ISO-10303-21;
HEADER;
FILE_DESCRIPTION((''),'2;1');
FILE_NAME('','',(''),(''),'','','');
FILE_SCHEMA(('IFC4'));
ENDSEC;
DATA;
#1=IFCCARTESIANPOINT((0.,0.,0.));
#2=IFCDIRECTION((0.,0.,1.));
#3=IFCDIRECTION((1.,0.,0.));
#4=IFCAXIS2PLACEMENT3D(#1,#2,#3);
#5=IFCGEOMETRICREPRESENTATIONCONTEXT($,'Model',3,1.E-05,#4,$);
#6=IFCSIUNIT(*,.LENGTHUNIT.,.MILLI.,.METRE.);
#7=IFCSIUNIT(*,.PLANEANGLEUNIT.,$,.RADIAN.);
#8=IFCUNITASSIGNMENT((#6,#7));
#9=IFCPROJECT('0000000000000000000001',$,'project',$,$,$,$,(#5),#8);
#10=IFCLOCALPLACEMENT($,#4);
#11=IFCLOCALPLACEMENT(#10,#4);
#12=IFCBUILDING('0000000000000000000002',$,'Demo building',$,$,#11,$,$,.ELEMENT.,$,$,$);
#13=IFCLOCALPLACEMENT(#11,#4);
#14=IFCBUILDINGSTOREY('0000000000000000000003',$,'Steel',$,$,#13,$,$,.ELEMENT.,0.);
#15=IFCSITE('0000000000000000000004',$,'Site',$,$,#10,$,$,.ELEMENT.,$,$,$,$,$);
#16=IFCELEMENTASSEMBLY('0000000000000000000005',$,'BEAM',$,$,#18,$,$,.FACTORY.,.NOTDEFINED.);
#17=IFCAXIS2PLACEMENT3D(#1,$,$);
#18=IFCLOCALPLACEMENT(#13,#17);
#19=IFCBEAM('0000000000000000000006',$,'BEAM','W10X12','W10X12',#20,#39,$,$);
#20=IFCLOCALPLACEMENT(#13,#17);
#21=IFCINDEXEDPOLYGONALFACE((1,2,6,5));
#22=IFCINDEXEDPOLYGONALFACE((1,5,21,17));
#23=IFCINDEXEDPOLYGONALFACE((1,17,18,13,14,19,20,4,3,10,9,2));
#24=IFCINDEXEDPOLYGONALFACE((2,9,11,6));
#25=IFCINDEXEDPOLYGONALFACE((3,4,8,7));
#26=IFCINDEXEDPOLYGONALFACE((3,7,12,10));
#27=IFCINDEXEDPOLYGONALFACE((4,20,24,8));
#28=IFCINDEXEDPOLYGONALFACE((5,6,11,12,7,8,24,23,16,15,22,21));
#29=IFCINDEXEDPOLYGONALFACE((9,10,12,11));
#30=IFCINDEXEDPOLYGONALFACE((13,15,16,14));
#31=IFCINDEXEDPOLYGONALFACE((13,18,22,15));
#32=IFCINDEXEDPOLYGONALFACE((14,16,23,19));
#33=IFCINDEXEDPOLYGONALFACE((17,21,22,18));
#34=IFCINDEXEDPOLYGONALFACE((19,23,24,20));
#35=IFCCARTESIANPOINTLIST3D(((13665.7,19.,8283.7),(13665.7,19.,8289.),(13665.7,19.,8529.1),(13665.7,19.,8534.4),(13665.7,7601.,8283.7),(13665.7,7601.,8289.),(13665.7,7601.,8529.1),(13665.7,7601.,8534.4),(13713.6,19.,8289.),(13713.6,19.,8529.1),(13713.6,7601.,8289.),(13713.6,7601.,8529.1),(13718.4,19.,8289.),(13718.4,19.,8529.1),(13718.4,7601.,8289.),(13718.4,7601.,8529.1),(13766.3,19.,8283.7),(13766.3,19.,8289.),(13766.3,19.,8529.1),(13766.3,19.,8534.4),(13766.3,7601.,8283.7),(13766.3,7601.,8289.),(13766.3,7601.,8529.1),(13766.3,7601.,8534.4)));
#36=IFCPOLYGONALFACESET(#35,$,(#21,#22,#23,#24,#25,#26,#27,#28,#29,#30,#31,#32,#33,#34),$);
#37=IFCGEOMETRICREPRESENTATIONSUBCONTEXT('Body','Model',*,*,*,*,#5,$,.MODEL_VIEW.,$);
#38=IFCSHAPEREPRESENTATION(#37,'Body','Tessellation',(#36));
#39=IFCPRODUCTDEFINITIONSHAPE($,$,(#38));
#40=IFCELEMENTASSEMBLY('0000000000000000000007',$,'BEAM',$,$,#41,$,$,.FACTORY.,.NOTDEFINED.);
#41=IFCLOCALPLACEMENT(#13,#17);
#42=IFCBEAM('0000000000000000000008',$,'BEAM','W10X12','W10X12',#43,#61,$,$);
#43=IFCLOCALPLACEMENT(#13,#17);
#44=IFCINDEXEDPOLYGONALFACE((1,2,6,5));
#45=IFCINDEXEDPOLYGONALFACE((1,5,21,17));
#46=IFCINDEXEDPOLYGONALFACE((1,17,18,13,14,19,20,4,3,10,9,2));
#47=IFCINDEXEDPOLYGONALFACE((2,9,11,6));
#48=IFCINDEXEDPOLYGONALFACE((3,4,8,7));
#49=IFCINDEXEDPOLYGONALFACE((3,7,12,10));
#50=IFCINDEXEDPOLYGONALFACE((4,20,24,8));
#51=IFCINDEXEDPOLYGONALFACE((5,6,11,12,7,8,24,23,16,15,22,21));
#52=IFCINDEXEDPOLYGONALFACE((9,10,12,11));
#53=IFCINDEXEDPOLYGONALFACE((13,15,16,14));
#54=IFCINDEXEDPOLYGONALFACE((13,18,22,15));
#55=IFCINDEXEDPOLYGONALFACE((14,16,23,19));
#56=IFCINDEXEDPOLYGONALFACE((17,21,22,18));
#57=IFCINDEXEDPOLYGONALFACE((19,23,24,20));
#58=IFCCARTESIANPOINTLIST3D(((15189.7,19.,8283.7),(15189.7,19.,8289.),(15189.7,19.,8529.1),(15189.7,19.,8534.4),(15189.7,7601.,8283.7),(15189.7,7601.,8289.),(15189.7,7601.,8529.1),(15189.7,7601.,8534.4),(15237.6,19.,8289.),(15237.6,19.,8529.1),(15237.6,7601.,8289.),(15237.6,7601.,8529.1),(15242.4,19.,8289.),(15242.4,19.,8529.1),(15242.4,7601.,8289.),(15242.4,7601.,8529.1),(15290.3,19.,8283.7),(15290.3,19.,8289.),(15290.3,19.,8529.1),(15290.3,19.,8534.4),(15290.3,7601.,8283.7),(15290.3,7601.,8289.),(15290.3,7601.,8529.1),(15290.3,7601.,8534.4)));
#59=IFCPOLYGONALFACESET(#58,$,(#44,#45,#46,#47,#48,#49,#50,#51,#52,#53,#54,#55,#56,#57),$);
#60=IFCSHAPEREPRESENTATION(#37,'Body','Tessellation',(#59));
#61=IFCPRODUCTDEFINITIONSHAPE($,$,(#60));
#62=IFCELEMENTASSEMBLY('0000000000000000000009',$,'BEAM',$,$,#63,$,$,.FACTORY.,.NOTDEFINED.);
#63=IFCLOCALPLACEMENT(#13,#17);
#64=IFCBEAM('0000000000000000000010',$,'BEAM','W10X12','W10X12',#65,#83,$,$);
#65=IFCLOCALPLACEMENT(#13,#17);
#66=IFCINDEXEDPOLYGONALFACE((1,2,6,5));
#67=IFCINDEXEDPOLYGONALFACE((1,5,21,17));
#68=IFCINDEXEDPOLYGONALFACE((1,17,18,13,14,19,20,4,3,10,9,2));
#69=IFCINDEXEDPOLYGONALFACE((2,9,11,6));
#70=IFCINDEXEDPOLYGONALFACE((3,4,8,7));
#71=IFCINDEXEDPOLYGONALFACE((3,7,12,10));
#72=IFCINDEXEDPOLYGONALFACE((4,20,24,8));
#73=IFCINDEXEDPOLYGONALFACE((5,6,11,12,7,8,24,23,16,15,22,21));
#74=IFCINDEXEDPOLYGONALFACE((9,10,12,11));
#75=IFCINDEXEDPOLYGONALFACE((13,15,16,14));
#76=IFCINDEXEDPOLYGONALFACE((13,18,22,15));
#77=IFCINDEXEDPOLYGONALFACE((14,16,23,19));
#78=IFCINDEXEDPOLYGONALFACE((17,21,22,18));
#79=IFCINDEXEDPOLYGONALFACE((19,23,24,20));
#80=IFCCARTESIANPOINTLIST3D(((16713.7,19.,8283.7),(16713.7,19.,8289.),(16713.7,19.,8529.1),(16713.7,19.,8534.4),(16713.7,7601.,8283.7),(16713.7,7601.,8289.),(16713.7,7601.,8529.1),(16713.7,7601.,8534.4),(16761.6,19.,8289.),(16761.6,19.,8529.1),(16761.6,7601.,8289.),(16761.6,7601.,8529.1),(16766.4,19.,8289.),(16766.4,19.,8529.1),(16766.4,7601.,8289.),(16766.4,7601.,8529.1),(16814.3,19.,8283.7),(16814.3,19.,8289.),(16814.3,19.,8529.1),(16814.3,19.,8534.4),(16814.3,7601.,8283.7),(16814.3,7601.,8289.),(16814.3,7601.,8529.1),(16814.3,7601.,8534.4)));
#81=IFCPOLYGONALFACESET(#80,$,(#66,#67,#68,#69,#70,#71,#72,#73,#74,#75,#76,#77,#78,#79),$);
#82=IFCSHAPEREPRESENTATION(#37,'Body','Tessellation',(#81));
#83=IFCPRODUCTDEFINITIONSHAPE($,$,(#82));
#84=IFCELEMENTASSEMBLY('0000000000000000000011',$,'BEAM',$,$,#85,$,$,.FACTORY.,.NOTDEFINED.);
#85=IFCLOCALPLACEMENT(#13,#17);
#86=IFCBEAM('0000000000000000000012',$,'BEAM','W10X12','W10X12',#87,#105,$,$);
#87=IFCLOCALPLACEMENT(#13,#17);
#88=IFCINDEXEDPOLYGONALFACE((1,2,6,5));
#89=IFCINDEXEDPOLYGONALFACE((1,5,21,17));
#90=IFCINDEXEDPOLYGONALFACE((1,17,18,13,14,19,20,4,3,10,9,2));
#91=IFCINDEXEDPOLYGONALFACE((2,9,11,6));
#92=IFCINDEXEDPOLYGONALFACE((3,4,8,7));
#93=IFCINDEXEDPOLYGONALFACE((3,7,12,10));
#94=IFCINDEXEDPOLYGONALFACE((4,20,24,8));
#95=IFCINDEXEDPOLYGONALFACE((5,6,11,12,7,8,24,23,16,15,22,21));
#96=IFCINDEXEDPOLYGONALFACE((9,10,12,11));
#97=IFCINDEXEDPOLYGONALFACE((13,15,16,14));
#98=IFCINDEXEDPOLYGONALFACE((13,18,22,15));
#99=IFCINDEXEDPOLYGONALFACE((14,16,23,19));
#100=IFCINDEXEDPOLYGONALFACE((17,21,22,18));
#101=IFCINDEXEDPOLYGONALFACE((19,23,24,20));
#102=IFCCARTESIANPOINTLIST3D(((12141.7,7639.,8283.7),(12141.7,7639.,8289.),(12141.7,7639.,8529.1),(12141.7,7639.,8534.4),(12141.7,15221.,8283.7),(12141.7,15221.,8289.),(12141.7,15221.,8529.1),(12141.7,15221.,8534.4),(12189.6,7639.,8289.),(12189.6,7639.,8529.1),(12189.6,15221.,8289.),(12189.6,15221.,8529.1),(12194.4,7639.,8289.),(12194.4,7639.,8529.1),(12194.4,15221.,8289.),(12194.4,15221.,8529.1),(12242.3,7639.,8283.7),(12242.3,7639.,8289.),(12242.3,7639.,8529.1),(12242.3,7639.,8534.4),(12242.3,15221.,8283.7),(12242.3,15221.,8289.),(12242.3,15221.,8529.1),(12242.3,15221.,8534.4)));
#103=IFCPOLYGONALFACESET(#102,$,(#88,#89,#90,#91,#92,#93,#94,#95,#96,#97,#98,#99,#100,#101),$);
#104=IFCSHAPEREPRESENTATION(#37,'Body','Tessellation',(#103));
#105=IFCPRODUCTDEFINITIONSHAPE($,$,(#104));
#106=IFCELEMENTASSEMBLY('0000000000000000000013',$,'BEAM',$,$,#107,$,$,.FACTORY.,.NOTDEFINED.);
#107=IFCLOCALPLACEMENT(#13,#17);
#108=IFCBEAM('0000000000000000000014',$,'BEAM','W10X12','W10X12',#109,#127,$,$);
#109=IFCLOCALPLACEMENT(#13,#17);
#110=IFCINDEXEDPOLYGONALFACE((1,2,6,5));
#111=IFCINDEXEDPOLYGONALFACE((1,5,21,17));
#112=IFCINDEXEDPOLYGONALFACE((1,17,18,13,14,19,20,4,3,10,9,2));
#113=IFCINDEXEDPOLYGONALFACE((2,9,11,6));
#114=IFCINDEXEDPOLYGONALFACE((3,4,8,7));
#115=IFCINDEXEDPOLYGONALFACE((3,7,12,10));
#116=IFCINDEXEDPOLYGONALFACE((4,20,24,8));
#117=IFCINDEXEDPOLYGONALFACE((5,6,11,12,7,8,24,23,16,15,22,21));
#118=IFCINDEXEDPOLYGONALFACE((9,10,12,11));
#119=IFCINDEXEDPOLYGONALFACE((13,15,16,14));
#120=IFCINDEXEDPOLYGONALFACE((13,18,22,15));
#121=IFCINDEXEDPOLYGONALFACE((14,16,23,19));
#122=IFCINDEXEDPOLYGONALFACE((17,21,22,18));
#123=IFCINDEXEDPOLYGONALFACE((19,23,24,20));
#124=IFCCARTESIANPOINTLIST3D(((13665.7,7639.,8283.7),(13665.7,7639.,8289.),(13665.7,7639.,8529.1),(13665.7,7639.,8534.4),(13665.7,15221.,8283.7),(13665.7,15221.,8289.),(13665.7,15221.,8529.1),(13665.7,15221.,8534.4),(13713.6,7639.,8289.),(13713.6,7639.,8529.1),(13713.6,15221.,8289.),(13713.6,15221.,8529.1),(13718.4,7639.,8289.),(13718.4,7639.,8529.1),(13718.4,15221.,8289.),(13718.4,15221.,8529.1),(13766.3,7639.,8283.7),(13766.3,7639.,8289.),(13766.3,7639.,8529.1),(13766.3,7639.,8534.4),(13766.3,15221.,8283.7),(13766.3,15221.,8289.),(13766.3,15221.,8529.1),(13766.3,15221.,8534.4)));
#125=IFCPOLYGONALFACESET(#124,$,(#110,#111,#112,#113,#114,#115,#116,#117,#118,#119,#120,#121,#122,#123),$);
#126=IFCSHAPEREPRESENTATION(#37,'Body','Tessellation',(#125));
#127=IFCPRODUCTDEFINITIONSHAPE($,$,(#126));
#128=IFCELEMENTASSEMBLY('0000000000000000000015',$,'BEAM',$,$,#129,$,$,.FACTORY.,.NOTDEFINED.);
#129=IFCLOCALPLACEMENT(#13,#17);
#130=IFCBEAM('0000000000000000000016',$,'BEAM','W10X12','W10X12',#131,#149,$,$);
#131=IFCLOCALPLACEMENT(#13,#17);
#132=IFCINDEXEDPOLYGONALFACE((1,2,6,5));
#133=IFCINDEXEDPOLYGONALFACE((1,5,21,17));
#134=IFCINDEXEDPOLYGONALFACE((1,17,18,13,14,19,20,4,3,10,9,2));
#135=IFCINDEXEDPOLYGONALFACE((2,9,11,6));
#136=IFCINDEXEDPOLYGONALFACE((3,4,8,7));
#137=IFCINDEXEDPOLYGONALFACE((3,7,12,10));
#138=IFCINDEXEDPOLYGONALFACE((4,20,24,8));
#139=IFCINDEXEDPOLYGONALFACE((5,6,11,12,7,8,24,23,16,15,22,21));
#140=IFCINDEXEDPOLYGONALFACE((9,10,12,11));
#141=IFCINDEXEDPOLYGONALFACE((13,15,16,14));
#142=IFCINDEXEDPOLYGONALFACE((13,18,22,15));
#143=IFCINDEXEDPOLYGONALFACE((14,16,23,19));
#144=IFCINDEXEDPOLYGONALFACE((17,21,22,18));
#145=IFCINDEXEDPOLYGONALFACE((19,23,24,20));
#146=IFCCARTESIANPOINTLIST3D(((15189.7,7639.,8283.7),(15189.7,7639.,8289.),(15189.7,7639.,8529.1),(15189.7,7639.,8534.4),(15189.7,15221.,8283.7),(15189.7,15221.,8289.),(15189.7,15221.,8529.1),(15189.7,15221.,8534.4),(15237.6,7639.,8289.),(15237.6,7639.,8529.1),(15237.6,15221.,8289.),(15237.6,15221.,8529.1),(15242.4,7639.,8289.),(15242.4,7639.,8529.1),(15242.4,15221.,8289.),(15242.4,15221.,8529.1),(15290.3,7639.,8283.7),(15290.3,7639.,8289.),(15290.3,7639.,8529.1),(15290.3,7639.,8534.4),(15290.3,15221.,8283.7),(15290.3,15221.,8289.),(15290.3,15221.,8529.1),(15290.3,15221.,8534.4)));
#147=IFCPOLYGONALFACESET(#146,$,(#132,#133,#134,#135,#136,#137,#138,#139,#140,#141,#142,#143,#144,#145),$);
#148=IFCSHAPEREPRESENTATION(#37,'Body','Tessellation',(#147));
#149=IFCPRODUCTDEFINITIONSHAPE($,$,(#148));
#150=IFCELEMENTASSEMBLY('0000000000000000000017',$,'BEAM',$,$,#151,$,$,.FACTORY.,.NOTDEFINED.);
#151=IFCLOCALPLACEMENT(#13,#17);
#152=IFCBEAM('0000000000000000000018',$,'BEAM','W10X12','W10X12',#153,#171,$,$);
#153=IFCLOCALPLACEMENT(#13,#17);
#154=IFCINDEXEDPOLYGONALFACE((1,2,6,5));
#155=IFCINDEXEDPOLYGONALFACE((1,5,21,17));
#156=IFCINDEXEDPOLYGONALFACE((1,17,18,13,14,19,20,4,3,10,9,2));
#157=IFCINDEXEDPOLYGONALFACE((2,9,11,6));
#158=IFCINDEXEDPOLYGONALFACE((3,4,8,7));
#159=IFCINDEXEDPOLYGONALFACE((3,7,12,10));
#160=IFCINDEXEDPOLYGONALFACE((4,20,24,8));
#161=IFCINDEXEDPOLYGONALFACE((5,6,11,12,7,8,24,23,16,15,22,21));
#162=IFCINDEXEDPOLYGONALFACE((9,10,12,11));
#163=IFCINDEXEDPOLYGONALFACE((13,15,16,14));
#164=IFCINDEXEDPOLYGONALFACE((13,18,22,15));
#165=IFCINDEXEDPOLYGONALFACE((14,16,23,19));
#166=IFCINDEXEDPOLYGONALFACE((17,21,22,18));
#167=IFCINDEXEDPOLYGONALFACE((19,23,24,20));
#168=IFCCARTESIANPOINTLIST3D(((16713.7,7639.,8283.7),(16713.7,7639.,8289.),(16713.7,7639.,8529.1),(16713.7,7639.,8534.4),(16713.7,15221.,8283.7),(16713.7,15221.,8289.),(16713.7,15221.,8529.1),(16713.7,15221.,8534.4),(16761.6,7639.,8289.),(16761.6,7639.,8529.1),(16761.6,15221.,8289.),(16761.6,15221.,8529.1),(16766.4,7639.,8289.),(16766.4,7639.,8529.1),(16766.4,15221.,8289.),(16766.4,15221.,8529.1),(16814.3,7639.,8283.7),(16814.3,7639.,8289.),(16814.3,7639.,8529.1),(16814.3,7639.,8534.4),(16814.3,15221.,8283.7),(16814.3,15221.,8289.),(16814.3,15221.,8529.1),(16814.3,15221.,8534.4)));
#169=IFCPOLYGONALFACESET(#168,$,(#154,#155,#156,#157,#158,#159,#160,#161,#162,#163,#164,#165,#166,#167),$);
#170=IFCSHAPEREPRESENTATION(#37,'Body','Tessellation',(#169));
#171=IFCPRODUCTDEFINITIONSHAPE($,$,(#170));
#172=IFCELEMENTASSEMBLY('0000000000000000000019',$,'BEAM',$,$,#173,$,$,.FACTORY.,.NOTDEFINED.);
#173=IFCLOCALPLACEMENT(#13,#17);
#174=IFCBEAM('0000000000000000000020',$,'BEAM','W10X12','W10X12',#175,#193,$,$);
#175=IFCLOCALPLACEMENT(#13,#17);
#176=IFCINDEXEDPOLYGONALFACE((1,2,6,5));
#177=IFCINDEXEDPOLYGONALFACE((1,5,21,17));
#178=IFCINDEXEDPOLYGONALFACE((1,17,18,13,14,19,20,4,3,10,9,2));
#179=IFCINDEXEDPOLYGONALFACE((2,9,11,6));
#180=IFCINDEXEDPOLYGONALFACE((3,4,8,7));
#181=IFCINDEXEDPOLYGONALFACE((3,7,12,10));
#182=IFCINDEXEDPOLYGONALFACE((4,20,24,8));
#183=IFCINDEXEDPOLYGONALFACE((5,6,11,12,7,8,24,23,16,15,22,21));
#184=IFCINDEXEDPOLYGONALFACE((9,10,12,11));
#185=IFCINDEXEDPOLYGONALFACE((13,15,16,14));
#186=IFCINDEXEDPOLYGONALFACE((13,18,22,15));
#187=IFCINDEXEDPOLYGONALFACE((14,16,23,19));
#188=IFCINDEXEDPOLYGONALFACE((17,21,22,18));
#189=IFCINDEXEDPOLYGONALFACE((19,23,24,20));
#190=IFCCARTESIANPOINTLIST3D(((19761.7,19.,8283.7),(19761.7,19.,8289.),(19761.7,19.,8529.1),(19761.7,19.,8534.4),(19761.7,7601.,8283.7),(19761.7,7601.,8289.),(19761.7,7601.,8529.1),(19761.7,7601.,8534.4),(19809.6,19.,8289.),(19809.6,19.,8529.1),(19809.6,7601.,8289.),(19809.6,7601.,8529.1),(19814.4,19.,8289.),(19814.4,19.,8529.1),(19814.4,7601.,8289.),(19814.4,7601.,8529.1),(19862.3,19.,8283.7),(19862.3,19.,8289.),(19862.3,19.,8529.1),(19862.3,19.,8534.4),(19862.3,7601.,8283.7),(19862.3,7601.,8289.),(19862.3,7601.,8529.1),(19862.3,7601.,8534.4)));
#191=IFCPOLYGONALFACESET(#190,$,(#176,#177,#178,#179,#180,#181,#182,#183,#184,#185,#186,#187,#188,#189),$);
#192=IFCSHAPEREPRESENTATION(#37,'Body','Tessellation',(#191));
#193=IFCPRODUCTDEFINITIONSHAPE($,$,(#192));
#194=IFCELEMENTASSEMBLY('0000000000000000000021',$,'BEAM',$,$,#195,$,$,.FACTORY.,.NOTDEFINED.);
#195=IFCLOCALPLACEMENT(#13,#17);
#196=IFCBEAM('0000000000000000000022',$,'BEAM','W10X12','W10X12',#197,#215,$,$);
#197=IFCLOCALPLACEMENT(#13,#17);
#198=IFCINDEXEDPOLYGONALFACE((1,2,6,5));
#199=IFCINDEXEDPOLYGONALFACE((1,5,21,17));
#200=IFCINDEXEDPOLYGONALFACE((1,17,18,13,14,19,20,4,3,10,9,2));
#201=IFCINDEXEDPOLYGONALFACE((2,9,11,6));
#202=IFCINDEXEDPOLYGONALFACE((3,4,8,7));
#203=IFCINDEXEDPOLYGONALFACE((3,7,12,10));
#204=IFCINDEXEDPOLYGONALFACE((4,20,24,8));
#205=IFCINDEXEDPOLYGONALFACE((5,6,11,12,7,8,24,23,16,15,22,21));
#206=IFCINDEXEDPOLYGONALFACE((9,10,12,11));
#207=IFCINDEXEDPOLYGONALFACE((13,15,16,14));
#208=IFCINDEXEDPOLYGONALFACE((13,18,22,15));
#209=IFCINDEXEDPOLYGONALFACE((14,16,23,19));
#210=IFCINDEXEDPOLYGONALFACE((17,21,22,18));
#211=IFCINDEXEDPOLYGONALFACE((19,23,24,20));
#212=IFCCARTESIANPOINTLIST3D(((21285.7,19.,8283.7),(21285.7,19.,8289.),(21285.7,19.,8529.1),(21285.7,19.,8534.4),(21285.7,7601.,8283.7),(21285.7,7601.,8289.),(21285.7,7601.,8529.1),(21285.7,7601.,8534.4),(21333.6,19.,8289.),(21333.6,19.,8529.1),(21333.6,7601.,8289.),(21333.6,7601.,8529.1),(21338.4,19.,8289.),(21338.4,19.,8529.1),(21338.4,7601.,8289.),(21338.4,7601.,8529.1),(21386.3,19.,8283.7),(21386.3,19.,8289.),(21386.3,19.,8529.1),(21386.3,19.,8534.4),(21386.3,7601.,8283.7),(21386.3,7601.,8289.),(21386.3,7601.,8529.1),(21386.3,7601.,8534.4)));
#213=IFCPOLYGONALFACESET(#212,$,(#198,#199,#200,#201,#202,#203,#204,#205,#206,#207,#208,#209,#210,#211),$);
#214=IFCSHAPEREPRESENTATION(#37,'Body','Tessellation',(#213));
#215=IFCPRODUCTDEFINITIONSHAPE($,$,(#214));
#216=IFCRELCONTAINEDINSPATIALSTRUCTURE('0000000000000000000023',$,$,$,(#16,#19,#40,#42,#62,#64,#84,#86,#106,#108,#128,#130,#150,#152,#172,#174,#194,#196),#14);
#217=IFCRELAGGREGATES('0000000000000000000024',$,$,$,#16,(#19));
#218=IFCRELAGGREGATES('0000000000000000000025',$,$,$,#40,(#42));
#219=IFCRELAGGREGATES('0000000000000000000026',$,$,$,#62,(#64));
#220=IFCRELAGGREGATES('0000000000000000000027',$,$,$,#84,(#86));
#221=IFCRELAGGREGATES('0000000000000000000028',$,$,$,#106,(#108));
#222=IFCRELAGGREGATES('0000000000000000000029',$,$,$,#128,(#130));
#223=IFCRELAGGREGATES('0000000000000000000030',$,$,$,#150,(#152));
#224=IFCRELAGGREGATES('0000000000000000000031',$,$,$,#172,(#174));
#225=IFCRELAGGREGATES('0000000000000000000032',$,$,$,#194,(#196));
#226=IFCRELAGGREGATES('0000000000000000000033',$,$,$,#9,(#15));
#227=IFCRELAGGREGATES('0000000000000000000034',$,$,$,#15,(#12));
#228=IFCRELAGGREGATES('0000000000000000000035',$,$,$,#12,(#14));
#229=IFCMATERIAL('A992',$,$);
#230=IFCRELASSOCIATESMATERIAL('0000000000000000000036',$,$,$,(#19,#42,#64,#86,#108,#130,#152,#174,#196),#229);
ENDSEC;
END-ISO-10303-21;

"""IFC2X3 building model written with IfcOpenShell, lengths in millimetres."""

from ifc_helpers import new_model, si_unit, frame, origin, origin_with_axes, origin_2d, place, context, subcontext, project, spatial, i_section, extrude, material, element, aggregate, save


model = new_model("IFC2X3")

# Units and contexts
model_context = context("Model", 3, precision=1e-05, world=origin_with_axes())
body_context = subcontext(model_context, "Body", "Model", "MODEL_VIEW")
ifc_project = project(units=[si_unit("LENGTHUNIT", "METRE", prefix="MILLI"), si_unit("PLANEANGLEUNIT", "RADIAN")], contexts=[model_context])

# Site, building, storey
site_placement = place(None, origin_with_axes())
site = spatial("IfcSite", under=ifc_project, at=site_placement, Name="Site", CompositionType="ELEMENT")
building_placement = place(site_placement, origin_with_axes())
building = spatial("IfcBuilding", under=site, at=building_placement, Name="Demo building", CompositionType="ELEMENT")
placement = place(building_placement, origin_with_axes())
storey = spatial("IfcBuildingStorey", under=building, at=placement, Name="Steel", CompositionType="ELEMENT", Elevation=0.0)

# Shared definitions
ifc_material_1 = material(Name="A992")

# Element assemblies, beams
assembly_1 = element("IfcElementAssembly", 1, at=placement, inside=storey, Name="BEAM", AssemblyPlace="FACTORY", PredefinedType="NOTDEFINED")
beam_1_placement = place(placement, frame((13716.0, 19.1, 8409.1), z_axis=(0.0, 1.0, 0.0), x_axis=(-1.0, 0.0, 0.0)))
beam_1 = element("IfcBeam", 2, at=beam_1_placement, inside=storey, material=ifc_material_1, Name="BEAM", Description="W10X12", ObjectType="W10X12", context=body_context, shape_type="SweptSolid", body=[
    extrude(i_section(OverallWidth=100.6, OverallDepth=250.7, WebThickness=4.8, FlangeThickness=5.3, at=origin_2d()), origin(), (0.0, 0.0, 1.0), 7581.9),
])
aggregate(assembly_1, [beam_1])
assembly_2 = element("IfcElementAssembly", 3, at=placement, inside=storey, Name="BEAM", AssemblyPlace="FACTORY", PredefinedType="NOTDEFINED")
beam_2_placement = place(placement, frame((15240.0, 19.1, 8409.1), z_axis=(0.0, 1.0, 0.0), x_axis=(-1.0, 0.0, 0.0)))
beam_2 = element("IfcBeam", 4, at=beam_2_placement, inside=storey, material=ifc_material_1, Name="BEAM", Description="W10X12", ObjectType="W10X12", context=body_context, shape_type="SweptSolid", body=[
    extrude(i_section(OverallWidth=100.6, OverallDepth=250.7, WebThickness=4.8, FlangeThickness=5.3, at=origin_2d()), origin(), (0.0, 0.0, 1.0), 7581.9),
])
aggregate(assembly_2, [beam_2])
assembly_3 = element("IfcElementAssembly", 5, at=placement, inside=storey, Name="BEAM", AssemblyPlace="FACTORY", PredefinedType="NOTDEFINED")
beam_3_placement = place(placement, frame((16764.0, 19.1, 8409.1), z_axis=(0.0, 1.0, 0.0), x_axis=(-1.0, 0.0, 0.0)))
beam_3 = element("IfcBeam", 6, at=beam_3_placement, inside=storey, material=ifc_material_1, Name="BEAM", Description="W10X12", ObjectType="W10X12", context=body_context, shape_type="SweptSolid", body=[
    extrude(i_section(OverallWidth=100.6, OverallDepth=250.7, WebThickness=4.8, FlangeThickness=5.3, at=origin_2d()), origin(), (0.0, 0.0, 1.0), 7581.9),
])
aggregate(assembly_3, [beam_3])
assembly_4 = element("IfcElementAssembly", 7, at=placement, inside=storey, Name="BEAM", AssemblyPlace="FACTORY", PredefinedType="NOTDEFINED")
beam_4_placement = place(placement, frame((12192.0, 7639.1, 8409.1), z_axis=(0.0, 1.0, 0.0), x_axis=(-1.0, 0.0, 0.0)))
beam_4 = element("IfcBeam", 8, at=beam_4_placement, inside=storey, material=ifc_material_1, Name="BEAM", Description="W10X12", ObjectType="W10X12", context=body_context, shape_type="SweptSolid", body=[
    extrude(i_section(OverallWidth=100.6, OverallDepth=250.7, WebThickness=4.8, FlangeThickness=5.3, at=origin_2d()), origin(), (0.0, 0.0, 1.0), 7581.9),
])
aggregate(assembly_4, [beam_4])
assembly_5 = element("IfcElementAssembly", 9, at=placement, inside=storey, Name="BEAM", AssemblyPlace="FACTORY", PredefinedType="NOTDEFINED")
beam_5_placement = place(placement, frame((13716.0, 7639.1, 8409.1), z_axis=(0.0, 1.0, 0.0), x_axis=(-1.0, 0.0, 0.0)))
beam_5 = element("IfcBeam", 10, at=beam_5_placement, inside=storey, material=ifc_material_1, Name="BEAM", Description="W10X12", ObjectType="W10X12", context=body_context, shape_type="SweptSolid", body=[
    extrude(i_section(OverallWidth=100.6, OverallDepth=250.7, WebThickness=4.8, FlangeThickness=5.3, at=origin_2d()), origin(), (0.0, 0.0, 1.0), 7581.9),
])
aggregate(assembly_5, [beam_5])
assembly_6 = element("IfcElementAssembly", 11, at=placement, inside=storey, Name="BEAM", AssemblyPlace="FACTORY", PredefinedType="NOTDEFINED")
beam_6_placement = place(placement, frame((15240.0, 7639.1, 8409.1), z_axis=(0.0, 1.0, 0.0), x_axis=(-1.0, 0.0, 0.0)))
beam_6 = element("IfcBeam", 12, at=beam_6_placement, inside=storey, material=ifc_material_1, Name="BEAM", Description="W10X12", ObjectType="W10X12", context=body_context, shape_type="SweptSolid", body=[
    extrude(i_section(OverallWidth=100.6, OverallDepth=250.7, WebThickness=4.8, FlangeThickness=5.3, at=origin_2d()), origin(), (0.0, 0.0, 1.0), 7581.9),
])
aggregate(assembly_6, [beam_6])
assembly_7 = element("IfcElementAssembly", 13, at=placement, inside=storey, Name="BEAM", AssemblyPlace="FACTORY", PredefinedType="NOTDEFINED")
beam_7_placement = place(placement, frame((16764.0, 7639.1, 8409.1), z_axis=(0.0, 1.0, 0.0), x_axis=(-1.0, 0.0, 0.0)))
beam_7 = element("IfcBeam", 14, at=beam_7_placement, inside=storey, material=ifc_material_1, Name="BEAM", Description="W10X12", ObjectType="W10X12", context=body_context, shape_type="SweptSolid", body=[
    extrude(i_section(OverallWidth=100.6, OverallDepth=250.7, WebThickness=4.8, FlangeThickness=5.3, at=origin_2d()), origin(), (0.0, 0.0, 1.0), 7581.9),
])
aggregate(assembly_7, [beam_7])
assembly_8 = element("IfcElementAssembly", 15, at=placement, inside=storey, Name="BEAM", AssemblyPlace="FACTORY", PredefinedType="NOTDEFINED")
beam_8_placement = place(placement, frame((19812.0, 19.1, 8409.1), z_axis=(0.0, 1.0, 0.0), x_axis=(-1.0, 0.0, 0.0)))
beam_8 = element("IfcBeam", 16, at=beam_8_placement, inside=storey, material=ifc_material_1, Name="BEAM", Description="W10X12", ObjectType="W10X12", context=body_context, shape_type="SweptSolid", body=[
    extrude(i_section(OverallWidth=100.6, OverallDepth=250.7, WebThickness=4.8, FlangeThickness=5.3, at=origin_2d()), origin(), (0.0, 0.0, 1.0), 7581.9),
])
aggregate(assembly_8, [beam_8])
assembly_9 = element("IfcElementAssembly", 17, at=placement, inside=storey, Name="BEAM", AssemblyPlace="FACTORY", PredefinedType="NOTDEFINED")
beam_9_placement = place(placement, frame((21336.0, 19.1, 8409.1), z_axis=(0.0, 1.0, 0.0), x_axis=(-1.0, 0.0, 0.0)))
beam_9 = element("IfcBeam", 18, at=beam_9_placement, inside=storey, material=ifc_material_1, Name="BEAM", Description="W10X12", ObjectType="W10X12", context=body_context, shape_type="SweptSolid", body=[
    extrude(i_section(OverallWidth=100.6, OverallDepth=250.7, WebThickness=4.8, FlangeThickness=5.3, at=origin_2d()), origin(), (0.0, 0.0, 1.0), 7581.9),
])
aggregate(assembly_9, [beam_9])

save(model, "model.ifc")
